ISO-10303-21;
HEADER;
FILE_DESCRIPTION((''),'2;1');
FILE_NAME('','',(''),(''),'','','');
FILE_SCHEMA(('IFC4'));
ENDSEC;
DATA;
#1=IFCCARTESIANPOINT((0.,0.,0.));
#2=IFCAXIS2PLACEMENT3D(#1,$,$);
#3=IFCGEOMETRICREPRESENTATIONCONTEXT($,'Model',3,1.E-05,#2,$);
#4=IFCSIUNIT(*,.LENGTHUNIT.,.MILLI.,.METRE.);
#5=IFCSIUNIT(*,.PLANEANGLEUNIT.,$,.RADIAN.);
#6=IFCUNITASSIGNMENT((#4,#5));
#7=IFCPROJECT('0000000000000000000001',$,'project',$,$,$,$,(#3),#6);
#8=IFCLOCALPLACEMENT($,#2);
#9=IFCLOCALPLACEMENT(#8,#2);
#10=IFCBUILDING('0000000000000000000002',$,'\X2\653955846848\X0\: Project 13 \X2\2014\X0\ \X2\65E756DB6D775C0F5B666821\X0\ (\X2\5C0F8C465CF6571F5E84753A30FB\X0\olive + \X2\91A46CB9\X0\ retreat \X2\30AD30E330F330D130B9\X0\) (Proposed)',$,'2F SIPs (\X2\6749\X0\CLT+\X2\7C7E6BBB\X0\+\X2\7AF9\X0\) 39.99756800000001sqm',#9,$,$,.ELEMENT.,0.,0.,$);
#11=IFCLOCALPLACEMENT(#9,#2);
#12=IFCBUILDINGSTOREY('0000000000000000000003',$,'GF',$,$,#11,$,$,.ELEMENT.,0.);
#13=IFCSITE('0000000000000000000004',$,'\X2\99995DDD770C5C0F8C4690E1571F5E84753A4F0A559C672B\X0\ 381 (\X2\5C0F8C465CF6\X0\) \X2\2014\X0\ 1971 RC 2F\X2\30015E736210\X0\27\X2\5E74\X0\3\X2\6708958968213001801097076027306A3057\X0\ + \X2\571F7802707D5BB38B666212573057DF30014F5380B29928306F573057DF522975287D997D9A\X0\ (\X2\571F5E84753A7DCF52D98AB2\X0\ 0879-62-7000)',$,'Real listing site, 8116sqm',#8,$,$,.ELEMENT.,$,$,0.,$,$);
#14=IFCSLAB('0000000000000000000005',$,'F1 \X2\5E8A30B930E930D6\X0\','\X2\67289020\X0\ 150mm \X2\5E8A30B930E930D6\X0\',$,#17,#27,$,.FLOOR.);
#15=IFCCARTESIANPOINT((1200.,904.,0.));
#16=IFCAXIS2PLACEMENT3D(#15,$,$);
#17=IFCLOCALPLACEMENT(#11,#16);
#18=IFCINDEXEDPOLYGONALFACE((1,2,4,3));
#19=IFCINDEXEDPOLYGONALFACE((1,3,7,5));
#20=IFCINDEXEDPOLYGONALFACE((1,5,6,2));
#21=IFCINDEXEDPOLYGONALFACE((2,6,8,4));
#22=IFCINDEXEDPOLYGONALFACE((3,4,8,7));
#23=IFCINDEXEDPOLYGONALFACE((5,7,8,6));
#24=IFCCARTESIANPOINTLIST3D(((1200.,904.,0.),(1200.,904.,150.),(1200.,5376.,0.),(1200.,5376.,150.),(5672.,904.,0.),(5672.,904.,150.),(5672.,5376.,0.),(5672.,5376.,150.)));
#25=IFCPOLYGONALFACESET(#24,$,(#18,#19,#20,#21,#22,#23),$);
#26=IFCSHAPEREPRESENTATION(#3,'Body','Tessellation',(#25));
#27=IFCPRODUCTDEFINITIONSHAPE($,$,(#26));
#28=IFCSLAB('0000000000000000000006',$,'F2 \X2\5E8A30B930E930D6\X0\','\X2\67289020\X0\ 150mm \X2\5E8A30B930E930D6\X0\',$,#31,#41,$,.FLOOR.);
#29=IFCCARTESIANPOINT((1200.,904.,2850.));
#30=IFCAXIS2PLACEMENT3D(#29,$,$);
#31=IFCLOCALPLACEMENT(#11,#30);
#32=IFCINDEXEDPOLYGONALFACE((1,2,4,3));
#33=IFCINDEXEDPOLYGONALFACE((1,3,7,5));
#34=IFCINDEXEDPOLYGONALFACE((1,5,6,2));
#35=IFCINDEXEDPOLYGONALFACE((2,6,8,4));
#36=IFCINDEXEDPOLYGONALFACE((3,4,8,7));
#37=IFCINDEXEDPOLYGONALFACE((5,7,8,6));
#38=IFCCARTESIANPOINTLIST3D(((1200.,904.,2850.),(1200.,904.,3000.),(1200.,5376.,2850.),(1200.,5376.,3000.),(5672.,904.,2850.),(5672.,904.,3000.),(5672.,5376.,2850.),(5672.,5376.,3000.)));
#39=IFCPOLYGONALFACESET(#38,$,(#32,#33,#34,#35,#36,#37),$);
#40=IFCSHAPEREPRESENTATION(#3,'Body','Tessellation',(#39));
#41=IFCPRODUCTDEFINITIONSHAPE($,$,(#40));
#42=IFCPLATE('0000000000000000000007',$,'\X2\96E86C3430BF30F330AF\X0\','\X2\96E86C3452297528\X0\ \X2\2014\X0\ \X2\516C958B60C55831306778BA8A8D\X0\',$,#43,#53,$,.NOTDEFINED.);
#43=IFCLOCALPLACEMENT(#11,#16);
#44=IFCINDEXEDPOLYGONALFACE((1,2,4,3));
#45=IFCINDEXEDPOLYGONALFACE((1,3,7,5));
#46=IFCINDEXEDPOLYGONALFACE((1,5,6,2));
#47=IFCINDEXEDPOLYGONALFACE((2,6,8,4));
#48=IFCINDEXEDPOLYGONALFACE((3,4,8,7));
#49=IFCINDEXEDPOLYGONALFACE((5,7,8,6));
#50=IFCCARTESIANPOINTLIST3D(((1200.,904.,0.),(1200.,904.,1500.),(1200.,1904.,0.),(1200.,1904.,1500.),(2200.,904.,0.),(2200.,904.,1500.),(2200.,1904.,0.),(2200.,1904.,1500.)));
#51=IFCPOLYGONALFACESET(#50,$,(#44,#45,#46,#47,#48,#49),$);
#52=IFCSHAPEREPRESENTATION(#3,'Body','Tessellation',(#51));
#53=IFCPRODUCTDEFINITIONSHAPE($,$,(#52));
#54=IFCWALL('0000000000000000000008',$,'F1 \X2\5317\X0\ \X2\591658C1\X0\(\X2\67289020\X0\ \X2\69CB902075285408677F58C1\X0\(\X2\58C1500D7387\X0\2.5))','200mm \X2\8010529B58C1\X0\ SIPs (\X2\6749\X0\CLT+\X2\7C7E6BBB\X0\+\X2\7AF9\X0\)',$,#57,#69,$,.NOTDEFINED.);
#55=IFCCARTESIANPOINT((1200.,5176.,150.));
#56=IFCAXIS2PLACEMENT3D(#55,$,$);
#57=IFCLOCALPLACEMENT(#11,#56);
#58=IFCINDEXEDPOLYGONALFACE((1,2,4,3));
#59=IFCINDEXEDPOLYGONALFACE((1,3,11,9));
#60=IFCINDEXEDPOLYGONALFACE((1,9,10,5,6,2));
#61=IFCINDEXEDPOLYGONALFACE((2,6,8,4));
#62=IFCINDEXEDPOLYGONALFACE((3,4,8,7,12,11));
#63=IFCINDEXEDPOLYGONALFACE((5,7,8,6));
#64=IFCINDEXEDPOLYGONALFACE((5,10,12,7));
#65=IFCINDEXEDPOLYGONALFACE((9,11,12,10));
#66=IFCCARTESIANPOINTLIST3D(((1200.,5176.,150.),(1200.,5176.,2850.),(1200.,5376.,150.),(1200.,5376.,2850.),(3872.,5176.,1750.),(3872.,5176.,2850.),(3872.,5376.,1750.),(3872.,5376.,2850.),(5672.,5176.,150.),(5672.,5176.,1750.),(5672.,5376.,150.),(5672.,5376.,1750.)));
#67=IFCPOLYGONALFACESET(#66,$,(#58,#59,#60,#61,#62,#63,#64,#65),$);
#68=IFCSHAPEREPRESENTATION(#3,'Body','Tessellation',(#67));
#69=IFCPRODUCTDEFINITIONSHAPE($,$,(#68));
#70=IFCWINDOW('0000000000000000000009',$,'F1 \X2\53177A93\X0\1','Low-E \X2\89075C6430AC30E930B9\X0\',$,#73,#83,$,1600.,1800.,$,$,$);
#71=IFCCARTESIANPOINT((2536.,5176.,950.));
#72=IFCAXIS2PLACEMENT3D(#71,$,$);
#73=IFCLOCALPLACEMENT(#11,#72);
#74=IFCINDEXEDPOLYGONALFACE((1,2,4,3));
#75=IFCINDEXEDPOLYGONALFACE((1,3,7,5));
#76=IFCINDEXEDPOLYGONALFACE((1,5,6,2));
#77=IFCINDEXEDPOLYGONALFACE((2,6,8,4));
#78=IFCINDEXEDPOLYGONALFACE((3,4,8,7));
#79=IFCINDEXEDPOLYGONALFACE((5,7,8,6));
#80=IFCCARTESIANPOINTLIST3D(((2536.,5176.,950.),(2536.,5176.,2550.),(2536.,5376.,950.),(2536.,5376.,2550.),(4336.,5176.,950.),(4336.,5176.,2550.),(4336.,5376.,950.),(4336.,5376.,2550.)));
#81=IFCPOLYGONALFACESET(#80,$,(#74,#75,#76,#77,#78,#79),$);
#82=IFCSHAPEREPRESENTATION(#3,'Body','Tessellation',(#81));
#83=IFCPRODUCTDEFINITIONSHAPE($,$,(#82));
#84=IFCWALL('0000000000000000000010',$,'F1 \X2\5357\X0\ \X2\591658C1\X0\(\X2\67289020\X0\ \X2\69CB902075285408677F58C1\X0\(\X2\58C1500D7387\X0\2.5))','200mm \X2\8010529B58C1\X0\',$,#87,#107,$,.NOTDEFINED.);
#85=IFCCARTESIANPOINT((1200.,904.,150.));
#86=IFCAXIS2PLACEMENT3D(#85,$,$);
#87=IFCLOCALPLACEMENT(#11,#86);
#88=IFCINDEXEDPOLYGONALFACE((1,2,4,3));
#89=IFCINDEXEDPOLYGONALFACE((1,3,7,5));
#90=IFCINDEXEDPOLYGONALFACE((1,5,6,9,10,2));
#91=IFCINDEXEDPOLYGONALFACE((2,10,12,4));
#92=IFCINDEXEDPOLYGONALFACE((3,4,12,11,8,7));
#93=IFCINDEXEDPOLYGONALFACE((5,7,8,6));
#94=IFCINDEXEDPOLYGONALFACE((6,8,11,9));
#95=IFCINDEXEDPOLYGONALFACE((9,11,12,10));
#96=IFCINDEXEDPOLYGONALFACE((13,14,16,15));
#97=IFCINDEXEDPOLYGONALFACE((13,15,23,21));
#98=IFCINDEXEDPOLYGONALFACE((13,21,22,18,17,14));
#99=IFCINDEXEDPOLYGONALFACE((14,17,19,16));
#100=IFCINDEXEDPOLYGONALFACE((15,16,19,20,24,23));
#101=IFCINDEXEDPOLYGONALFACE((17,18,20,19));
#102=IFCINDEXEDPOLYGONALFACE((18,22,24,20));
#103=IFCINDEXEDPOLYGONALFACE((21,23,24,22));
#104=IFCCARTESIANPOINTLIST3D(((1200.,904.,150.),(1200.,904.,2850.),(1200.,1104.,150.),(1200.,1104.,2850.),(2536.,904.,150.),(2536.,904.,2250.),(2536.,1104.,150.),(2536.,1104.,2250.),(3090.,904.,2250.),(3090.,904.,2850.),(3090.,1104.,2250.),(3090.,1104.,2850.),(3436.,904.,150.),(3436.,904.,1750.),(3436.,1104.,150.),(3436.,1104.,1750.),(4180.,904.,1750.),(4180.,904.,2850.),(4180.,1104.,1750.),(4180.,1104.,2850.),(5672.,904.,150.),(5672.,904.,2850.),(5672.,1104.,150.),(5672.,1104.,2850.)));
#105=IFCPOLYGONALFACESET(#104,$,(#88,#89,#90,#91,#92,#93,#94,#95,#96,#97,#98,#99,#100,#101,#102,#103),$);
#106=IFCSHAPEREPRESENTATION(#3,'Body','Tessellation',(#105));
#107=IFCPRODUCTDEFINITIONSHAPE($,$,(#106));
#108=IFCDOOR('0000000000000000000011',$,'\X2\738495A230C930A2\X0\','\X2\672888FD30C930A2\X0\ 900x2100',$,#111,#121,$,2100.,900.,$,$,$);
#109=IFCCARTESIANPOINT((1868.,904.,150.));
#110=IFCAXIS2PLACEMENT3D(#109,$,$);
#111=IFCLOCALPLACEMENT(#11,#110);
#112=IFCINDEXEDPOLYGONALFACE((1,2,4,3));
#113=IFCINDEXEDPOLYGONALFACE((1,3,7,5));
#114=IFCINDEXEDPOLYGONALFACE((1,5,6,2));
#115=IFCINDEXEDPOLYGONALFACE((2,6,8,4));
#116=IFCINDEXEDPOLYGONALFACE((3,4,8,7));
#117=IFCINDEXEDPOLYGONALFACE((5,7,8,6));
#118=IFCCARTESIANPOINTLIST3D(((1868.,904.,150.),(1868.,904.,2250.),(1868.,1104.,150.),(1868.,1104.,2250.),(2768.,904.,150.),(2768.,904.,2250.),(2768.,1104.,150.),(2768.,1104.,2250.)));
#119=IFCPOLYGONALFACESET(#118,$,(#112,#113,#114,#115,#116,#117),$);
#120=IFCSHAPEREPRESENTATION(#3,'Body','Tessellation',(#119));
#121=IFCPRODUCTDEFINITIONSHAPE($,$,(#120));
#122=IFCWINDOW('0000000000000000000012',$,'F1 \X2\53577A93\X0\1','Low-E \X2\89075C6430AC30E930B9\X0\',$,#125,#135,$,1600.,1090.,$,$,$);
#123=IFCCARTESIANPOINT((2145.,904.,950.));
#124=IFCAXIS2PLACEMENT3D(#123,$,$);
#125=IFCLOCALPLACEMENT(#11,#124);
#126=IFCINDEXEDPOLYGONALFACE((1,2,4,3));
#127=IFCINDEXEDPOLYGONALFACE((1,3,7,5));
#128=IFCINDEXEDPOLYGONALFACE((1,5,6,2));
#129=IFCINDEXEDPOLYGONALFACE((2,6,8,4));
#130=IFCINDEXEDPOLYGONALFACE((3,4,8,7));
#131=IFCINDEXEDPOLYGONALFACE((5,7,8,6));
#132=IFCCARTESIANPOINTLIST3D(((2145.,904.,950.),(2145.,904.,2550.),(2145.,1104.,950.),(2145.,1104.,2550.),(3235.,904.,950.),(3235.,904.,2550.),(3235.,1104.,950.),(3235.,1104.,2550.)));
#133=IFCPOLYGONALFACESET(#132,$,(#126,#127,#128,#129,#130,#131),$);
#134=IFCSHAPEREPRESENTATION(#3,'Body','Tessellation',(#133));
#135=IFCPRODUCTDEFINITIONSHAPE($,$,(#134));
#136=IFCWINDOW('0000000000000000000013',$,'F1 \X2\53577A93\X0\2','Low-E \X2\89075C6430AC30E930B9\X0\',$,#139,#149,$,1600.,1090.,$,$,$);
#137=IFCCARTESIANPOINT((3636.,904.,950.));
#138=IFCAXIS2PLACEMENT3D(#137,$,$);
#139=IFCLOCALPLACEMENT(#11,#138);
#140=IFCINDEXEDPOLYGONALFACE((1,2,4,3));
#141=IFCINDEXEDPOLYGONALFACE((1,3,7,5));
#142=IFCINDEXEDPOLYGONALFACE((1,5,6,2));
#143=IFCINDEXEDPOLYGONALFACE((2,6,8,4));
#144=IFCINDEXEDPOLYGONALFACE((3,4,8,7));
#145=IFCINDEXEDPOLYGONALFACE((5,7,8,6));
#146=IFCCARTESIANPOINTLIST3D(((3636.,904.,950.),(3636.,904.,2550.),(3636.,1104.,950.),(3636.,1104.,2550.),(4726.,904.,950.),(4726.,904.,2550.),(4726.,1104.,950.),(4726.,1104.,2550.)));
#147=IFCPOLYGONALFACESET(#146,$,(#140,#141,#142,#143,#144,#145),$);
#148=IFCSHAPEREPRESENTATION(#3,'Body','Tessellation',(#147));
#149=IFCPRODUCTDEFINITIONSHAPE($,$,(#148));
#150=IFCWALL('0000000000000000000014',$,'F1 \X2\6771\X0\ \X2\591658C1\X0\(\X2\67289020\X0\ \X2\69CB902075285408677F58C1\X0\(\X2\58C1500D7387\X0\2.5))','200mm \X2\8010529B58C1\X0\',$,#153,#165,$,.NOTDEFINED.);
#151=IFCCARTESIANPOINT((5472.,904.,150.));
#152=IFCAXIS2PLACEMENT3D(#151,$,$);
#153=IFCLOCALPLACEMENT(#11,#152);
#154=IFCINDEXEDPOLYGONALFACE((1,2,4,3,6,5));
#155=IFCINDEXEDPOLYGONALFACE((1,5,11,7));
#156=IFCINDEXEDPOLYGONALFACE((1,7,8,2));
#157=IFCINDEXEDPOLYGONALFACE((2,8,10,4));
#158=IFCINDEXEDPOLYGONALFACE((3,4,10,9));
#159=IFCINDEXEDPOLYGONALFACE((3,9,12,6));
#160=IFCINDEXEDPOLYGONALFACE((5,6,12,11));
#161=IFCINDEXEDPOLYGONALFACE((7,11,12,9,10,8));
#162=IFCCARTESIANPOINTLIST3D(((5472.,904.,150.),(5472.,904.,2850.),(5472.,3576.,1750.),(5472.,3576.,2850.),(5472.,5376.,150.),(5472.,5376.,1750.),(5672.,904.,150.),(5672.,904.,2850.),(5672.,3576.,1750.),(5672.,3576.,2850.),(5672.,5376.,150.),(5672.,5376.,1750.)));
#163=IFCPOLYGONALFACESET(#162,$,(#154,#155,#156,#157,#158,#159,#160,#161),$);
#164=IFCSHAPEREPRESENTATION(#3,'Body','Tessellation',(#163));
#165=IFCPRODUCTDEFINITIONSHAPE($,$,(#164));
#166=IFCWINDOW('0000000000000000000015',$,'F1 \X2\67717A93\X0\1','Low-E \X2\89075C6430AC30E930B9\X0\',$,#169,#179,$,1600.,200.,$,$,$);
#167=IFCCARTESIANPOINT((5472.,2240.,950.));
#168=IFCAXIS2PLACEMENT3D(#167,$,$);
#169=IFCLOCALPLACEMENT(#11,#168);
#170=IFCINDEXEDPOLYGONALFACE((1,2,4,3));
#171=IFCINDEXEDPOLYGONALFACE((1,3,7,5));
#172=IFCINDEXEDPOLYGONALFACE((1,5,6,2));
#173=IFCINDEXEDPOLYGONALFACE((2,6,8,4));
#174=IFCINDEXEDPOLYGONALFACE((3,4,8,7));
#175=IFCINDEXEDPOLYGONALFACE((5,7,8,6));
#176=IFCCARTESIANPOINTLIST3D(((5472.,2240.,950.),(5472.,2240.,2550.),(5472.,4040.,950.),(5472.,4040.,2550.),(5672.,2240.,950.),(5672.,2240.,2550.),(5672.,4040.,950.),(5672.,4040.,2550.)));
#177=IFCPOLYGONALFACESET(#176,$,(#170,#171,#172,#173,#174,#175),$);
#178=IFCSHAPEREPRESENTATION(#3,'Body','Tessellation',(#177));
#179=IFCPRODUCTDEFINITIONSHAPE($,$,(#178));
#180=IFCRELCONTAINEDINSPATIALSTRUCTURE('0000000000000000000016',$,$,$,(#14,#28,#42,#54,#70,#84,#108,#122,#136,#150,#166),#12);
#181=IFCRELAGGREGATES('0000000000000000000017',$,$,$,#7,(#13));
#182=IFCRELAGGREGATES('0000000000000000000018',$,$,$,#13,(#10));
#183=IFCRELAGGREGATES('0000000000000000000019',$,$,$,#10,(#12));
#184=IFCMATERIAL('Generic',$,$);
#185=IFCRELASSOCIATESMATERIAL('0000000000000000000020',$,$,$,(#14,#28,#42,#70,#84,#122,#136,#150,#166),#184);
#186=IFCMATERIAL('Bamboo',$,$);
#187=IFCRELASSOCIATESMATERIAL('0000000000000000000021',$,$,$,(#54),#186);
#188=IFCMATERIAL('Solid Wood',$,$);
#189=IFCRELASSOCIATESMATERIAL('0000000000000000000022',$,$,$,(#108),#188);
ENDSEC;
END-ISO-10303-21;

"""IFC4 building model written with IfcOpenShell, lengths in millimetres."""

from ifc_helpers import new_model, si_unit, frame, frame_2d, origin, place, context, project, spatial, rectangle, extrude, material, element, fill, save


model = new_model("IFC4")

# Units and contexts
model_context = context("Model", 3, precision=1e-05, world=origin())
ifc_project = project(units=[si_unit("LENGTHUNIT", "METRE", prefix="MILLI"), si_unit("PLANEANGLEUNIT", "RADIAN")], contexts=[model_context])

# Site, building, storey
site_placement = place(None, origin())
site = spatial("IfcSite", under=ifc_project, at=site_placement, Name="香川県小豆郡土庄町伊喜末 381 (小豆島) — 1971 RC 2F、平成27年3月閉校、耐震性なし + 土砂災害警戒地域、体育館は地域利用継続 (土庄町総務課 0879-62-7000)", ObjectType="Real listing site, 8116sqm", CompositionType="ELEMENT", RefElevation=0.0)
building_placement = place(site_placement, origin())
building = spatial("IfcBuilding", under=site, at=building_placement, Name="改善案: Project 13 — 旧四海小学校 (小豆島土庄町・olive + 醤油 retreat キャンパス) (Proposed)", ObjectType="2F SIPs (杉CLT+籾殻+竹) 39.99756800000001sqm", CompositionType="ELEMENT", ElevationOfRefHeight=0.0, ElevationOfTerrain=0.0)
storey_placement = place(building_placement, origin())
storey = spatial("IfcBuildingStorey", under=building, at=storey_placement, Name="GF", CompositionType="ELEMENT", Elevation=0.0)

# Slabs
ifc_material_1 = material(Name="Generic")
slab_1_placement = place(storey_placement, frame((1200.0, 904.0, 0.0)))
element("IfcSlab", 1, at=slab_1_placement, inside=storey, material=ifc_material_1, Name="F1 床スラブ", Description="木造 150mm 床スラブ", PredefinedType="FLOOR", context=model_context, shape_type="SweptSolid", body=[
    extrude(rectangle(XDim=4472.0, YDim=4472.0, at=frame_2d((2236.0, 2236.0))), frame((1200.0, 904.0, 0.0)), (0.0, 0.0, 1.0), 150.0),
])
slab_2_placement = place(storey_placement, frame((1200.0, 904.0, 2850.0)))
element("IfcSlab", 2, at=slab_2_placement, inside=storey, material=ifc_material_1, Name="F2 床スラブ", Description="木造 150mm 床スラブ", PredefinedType="FLOOR", context=model_context, shape_type="SweptSolid", body=[
    extrude(rectangle(XDim=4472.0, YDim=4472.0, at=frame_2d((2236.0, 2236.0))), frame((1200.0, 904.0, 2850.0)), (0.0, 0.0, 1.0), 150.0),
])

# Plate
plate_placement = place(storey_placement, frame((1200.0, 904.0, 0.0)))
element("IfcPlate", 3, at=plate_placement, inside=storey, material=ifc_material_1, Name="雨水タンク", Description="雨水利用 — 公開情報で確認", PredefinedType="NOTDEFINED", context=model_context, shape_type="SweptSolid", body=[
    extrude(rectangle(XDim=1000.0, YDim=1000.0, at=frame_2d((500.0, 500.0))), frame((1200.0, 904.0, 0.0)), (0.0, 0.0, 1.0), 1500.0),
])

# Wall, opening, window
ifc_material_2 = material(Name="Bamboo")
wall_1_placement = place(storey_placement, frame((1200.0, 5176.0, 150.0)))
wall_1 = element("IfcWall", 4, at=wall_1_placement, inside=storey, material=ifc_material_2, Name="F1 北 外壁(木造 構造用合板壁(壁倍率2.5))", Description="200mm 耐力壁 SIPs (杉CLT+籾殻+竹)", PredefinedType="NOTDEFINED", context=model_context, shape_type="SweptSolid", body=[
    extrude(rectangle(XDim=4472.0, YDim=200.0, at=frame_2d((2236.0, 100.0))), frame((1200.0, 5176.0, 150.0)), (0.0, 0.0, 1.0), 2700.0),
])
opening_1_placement = place(storey_placement, frame((2536.0, 5176.0, 950.0)))
opening_1 = element("IfcOpeningElement", 5, at=opening_1_placement, cuts=wall_1, PredefinedType="NOTDEFINED", context=model_context, shape_type="SweptSolid", body=[
    extrude(rectangle(XDim=1800.0, YDim=200.0, at=frame_2d((900.0, 100.0))), frame((2536.0, 5176.0, 950.0)), (0.0, 0.0, 1.0), 1600.0),
])
window_1_placement = place(storey_placement, frame((2536.0, 5176.0, 950.0)))
window_1 = element("IfcWindow", 6, at=window_1_placement, inside=storey, material=ifc_material_1, Name="F1 北窓1", Description="Low-E 複層ガラス", OverallHeight=1600.0, OverallWidth=1800.0, context=model_context, shape_type="SweptSolid", body=[
    extrude(rectangle(XDim=1800.0, YDim=200.0, at=frame_2d((900.0, 100.0))), frame((2536.0, 5176.0, 950.0)), (0.0, 0.0, 1.0), 1600.0),
])
fill(opening_1, window_1)

# Wall, openings, door, windows
wall_2_placement = place(storey_placement, frame((1200.0, 904.0, 150.0)))
wall_2 = element("IfcWall", 7, at=wall_2_placement, inside=storey, material=ifc_material_1, Name="F1 南 外壁(木造 構造用合板壁(壁倍率2.5))", Description="200mm 耐力壁", PredefinedType="NOTDEFINED", context=model_context, shape_type="SweptSolid", body=[
    extrude(rectangle(XDim=4472.0, YDim=200.0, at=frame_2d((2236.0, 100.0))), frame((1200.0, 904.0, 150.0)), (0.0, 0.0, 1.0), 2700.0),
])
opening_2_placement = place(storey_placement, frame((1868.0, 904.0, 150.0)))
opening_2 = element("IfcOpeningElement", 8, at=opening_2_placement, cuts=wall_2, PredefinedType="NOTDEFINED", context=model_context, shape_type="SweptSolid", body=[
    extrude(rectangle(XDim=900.0, YDim=200.0, at=frame_2d((450.0, 100.0))), frame((1868.0, 904.0, 150.0)), (0.0, 0.0, 1.0), 2100.0),
])
opening_3_placement = place(storey_placement, frame((2145.0, 904.0, 950.0)))
opening_3 = element("IfcOpeningElement", 9, at=opening_3_placement, cuts=wall_2, PredefinedType="NOTDEFINED", context=model_context, shape_type="SweptSolid", body=[
    extrude(rectangle(XDim=1090.0, YDim=200.0, at=frame_2d((545.0, 100.0))), frame((2145.0, 904.0, 950.0)), (0.0, 0.0, 1.0), 1600.0),
])
opening_4_placement = place(storey_placement, frame((3636.0, 904.0, 950.0)))
opening_4 = element("IfcOpeningElement", 10, at=opening_4_placement, cuts=wall_2, PredefinedType="NOTDEFINED", context=model_context, shape_type="SweptSolid", body=[
    extrude(rectangle(XDim=1090.0, YDim=200.0, at=frame_2d((545.0, 100.0))), frame((3636.0, 904.0, 950.0)), (0.0, 0.0, 1.0), 1600.0),
])
ifc_material_3 = material(Name="Solid Wood")
door_placement = place(storey_placement, frame((1868.0, 904.0, 150.0)))
door = element("IfcDoor", 11, at=door_placement, inside=storey, material=ifc_material_3, Name="玄関ドア", Description="木製ドア 900x2100", OverallHeight=2100.0, OverallWidth=900.0, context=model_context, shape_type="SweptSolid", body=[
    extrude(rectangle(XDim=900.0, YDim=200.0, at=frame_2d((450.0, 100.0))), frame((1868.0, 904.0, 150.0)), (0.0, 0.0, 1.0), 2100.0),
])
fill(opening_2, door)
window_2_placement = place(storey_placement, frame((2145.0, 904.0, 950.0)))
window_2 = element("IfcWindow", 12, at=window_2_placement, inside=storey, material=ifc_material_1, Name="F1 南窓1", Description="Low-E 複層ガラス", OverallHeight=1600.0, OverallWidth=1090.0, context=model_context, shape_type="SweptSolid", body=[
    extrude(rectangle(XDim=1090.0, YDim=200.0, at=frame_2d((545.0, 100.0))), frame((2145.0, 904.0, 950.0)), (0.0, 0.0, 1.0), 1600.0),
])
fill(opening_3, window_2)
window_3_placement = place(storey_placement, frame((3636.0, 904.0, 950.0)))
window_3 = element("IfcWindow", 13, at=window_3_placement, inside=storey, material=ifc_material_1, Name="F1 南窓2", Description="Low-E 複層ガラス", OverallHeight=1600.0, OverallWidth=1090.0, context=model_context, shape_type="SweptSolid", body=[
    extrude(rectangle(XDim=1090.0, YDim=200.0, at=frame_2d((545.0, 100.0))), frame((3636.0, 904.0, 950.0)), (0.0, 0.0, 1.0), 1600.0),
])
fill(opening_4, window_3)

# Wall, opening, window
wall_3_placement = place(storey_placement, frame((5472.0, 904.0, 150.0)))
wall_3 = element("IfcWall", 14, at=wall_3_placement, inside=storey, material=ifc_material_1, Name="F1 東 外壁(木造 構造用合板壁(壁倍率2.5))", Description="200mm 耐力壁", PredefinedType="NOTDEFINED", context=model_context, shape_type="SweptSolid", body=[
    extrude(rectangle(XDim=200.0, YDim=4472.0, at=frame_2d((100.0, 2236.0))), frame((5472.0, 904.0, 150.0)), (0.0, 0.0, 1.0), 2700.0),
])
opening_5_placement = place(storey_placement, frame((5472.0, 2240.0, 950.0)))
opening_5 = element("IfcOpeningElement", 15, at=opening_5_placement, cuts=wall_3, PredefinedType="NOTDEFINED", context=model_context, shape_type="SweptSolid", body=[
    extrude(rectangle(XDim=200.0, YDim=1800.0, at=frame_2d((100.0, 900.0))), frame((5472.0, 2240.0, 950.0)), (0.0, 0.0, 1.0), 1600.0),
])
window_4_placement = place(storey_placement, frame((5472.0, 2240.0, 950.0)))
window_4 = element("IfcWindow", 16, at=window_4_placement, inside=storey, material=ifc_material_1, Name="F1 東窓1", Description="Low-E 複層ガラス", OverallHeight=1600.0, OverallWidth=200.0, context=model_context, shape_type="SweptSolid", body=[
    extrude(rectangle(XDim=200.0, YDim=1800.0, at=frame_2d((100.0, 900.0))), frame((5472.0, 2240.0, 950.0)), (0.0, 0.0, 1.0), 1600.0),
])
fill(opening_5, window_4)

save(model, "model.ifc")
